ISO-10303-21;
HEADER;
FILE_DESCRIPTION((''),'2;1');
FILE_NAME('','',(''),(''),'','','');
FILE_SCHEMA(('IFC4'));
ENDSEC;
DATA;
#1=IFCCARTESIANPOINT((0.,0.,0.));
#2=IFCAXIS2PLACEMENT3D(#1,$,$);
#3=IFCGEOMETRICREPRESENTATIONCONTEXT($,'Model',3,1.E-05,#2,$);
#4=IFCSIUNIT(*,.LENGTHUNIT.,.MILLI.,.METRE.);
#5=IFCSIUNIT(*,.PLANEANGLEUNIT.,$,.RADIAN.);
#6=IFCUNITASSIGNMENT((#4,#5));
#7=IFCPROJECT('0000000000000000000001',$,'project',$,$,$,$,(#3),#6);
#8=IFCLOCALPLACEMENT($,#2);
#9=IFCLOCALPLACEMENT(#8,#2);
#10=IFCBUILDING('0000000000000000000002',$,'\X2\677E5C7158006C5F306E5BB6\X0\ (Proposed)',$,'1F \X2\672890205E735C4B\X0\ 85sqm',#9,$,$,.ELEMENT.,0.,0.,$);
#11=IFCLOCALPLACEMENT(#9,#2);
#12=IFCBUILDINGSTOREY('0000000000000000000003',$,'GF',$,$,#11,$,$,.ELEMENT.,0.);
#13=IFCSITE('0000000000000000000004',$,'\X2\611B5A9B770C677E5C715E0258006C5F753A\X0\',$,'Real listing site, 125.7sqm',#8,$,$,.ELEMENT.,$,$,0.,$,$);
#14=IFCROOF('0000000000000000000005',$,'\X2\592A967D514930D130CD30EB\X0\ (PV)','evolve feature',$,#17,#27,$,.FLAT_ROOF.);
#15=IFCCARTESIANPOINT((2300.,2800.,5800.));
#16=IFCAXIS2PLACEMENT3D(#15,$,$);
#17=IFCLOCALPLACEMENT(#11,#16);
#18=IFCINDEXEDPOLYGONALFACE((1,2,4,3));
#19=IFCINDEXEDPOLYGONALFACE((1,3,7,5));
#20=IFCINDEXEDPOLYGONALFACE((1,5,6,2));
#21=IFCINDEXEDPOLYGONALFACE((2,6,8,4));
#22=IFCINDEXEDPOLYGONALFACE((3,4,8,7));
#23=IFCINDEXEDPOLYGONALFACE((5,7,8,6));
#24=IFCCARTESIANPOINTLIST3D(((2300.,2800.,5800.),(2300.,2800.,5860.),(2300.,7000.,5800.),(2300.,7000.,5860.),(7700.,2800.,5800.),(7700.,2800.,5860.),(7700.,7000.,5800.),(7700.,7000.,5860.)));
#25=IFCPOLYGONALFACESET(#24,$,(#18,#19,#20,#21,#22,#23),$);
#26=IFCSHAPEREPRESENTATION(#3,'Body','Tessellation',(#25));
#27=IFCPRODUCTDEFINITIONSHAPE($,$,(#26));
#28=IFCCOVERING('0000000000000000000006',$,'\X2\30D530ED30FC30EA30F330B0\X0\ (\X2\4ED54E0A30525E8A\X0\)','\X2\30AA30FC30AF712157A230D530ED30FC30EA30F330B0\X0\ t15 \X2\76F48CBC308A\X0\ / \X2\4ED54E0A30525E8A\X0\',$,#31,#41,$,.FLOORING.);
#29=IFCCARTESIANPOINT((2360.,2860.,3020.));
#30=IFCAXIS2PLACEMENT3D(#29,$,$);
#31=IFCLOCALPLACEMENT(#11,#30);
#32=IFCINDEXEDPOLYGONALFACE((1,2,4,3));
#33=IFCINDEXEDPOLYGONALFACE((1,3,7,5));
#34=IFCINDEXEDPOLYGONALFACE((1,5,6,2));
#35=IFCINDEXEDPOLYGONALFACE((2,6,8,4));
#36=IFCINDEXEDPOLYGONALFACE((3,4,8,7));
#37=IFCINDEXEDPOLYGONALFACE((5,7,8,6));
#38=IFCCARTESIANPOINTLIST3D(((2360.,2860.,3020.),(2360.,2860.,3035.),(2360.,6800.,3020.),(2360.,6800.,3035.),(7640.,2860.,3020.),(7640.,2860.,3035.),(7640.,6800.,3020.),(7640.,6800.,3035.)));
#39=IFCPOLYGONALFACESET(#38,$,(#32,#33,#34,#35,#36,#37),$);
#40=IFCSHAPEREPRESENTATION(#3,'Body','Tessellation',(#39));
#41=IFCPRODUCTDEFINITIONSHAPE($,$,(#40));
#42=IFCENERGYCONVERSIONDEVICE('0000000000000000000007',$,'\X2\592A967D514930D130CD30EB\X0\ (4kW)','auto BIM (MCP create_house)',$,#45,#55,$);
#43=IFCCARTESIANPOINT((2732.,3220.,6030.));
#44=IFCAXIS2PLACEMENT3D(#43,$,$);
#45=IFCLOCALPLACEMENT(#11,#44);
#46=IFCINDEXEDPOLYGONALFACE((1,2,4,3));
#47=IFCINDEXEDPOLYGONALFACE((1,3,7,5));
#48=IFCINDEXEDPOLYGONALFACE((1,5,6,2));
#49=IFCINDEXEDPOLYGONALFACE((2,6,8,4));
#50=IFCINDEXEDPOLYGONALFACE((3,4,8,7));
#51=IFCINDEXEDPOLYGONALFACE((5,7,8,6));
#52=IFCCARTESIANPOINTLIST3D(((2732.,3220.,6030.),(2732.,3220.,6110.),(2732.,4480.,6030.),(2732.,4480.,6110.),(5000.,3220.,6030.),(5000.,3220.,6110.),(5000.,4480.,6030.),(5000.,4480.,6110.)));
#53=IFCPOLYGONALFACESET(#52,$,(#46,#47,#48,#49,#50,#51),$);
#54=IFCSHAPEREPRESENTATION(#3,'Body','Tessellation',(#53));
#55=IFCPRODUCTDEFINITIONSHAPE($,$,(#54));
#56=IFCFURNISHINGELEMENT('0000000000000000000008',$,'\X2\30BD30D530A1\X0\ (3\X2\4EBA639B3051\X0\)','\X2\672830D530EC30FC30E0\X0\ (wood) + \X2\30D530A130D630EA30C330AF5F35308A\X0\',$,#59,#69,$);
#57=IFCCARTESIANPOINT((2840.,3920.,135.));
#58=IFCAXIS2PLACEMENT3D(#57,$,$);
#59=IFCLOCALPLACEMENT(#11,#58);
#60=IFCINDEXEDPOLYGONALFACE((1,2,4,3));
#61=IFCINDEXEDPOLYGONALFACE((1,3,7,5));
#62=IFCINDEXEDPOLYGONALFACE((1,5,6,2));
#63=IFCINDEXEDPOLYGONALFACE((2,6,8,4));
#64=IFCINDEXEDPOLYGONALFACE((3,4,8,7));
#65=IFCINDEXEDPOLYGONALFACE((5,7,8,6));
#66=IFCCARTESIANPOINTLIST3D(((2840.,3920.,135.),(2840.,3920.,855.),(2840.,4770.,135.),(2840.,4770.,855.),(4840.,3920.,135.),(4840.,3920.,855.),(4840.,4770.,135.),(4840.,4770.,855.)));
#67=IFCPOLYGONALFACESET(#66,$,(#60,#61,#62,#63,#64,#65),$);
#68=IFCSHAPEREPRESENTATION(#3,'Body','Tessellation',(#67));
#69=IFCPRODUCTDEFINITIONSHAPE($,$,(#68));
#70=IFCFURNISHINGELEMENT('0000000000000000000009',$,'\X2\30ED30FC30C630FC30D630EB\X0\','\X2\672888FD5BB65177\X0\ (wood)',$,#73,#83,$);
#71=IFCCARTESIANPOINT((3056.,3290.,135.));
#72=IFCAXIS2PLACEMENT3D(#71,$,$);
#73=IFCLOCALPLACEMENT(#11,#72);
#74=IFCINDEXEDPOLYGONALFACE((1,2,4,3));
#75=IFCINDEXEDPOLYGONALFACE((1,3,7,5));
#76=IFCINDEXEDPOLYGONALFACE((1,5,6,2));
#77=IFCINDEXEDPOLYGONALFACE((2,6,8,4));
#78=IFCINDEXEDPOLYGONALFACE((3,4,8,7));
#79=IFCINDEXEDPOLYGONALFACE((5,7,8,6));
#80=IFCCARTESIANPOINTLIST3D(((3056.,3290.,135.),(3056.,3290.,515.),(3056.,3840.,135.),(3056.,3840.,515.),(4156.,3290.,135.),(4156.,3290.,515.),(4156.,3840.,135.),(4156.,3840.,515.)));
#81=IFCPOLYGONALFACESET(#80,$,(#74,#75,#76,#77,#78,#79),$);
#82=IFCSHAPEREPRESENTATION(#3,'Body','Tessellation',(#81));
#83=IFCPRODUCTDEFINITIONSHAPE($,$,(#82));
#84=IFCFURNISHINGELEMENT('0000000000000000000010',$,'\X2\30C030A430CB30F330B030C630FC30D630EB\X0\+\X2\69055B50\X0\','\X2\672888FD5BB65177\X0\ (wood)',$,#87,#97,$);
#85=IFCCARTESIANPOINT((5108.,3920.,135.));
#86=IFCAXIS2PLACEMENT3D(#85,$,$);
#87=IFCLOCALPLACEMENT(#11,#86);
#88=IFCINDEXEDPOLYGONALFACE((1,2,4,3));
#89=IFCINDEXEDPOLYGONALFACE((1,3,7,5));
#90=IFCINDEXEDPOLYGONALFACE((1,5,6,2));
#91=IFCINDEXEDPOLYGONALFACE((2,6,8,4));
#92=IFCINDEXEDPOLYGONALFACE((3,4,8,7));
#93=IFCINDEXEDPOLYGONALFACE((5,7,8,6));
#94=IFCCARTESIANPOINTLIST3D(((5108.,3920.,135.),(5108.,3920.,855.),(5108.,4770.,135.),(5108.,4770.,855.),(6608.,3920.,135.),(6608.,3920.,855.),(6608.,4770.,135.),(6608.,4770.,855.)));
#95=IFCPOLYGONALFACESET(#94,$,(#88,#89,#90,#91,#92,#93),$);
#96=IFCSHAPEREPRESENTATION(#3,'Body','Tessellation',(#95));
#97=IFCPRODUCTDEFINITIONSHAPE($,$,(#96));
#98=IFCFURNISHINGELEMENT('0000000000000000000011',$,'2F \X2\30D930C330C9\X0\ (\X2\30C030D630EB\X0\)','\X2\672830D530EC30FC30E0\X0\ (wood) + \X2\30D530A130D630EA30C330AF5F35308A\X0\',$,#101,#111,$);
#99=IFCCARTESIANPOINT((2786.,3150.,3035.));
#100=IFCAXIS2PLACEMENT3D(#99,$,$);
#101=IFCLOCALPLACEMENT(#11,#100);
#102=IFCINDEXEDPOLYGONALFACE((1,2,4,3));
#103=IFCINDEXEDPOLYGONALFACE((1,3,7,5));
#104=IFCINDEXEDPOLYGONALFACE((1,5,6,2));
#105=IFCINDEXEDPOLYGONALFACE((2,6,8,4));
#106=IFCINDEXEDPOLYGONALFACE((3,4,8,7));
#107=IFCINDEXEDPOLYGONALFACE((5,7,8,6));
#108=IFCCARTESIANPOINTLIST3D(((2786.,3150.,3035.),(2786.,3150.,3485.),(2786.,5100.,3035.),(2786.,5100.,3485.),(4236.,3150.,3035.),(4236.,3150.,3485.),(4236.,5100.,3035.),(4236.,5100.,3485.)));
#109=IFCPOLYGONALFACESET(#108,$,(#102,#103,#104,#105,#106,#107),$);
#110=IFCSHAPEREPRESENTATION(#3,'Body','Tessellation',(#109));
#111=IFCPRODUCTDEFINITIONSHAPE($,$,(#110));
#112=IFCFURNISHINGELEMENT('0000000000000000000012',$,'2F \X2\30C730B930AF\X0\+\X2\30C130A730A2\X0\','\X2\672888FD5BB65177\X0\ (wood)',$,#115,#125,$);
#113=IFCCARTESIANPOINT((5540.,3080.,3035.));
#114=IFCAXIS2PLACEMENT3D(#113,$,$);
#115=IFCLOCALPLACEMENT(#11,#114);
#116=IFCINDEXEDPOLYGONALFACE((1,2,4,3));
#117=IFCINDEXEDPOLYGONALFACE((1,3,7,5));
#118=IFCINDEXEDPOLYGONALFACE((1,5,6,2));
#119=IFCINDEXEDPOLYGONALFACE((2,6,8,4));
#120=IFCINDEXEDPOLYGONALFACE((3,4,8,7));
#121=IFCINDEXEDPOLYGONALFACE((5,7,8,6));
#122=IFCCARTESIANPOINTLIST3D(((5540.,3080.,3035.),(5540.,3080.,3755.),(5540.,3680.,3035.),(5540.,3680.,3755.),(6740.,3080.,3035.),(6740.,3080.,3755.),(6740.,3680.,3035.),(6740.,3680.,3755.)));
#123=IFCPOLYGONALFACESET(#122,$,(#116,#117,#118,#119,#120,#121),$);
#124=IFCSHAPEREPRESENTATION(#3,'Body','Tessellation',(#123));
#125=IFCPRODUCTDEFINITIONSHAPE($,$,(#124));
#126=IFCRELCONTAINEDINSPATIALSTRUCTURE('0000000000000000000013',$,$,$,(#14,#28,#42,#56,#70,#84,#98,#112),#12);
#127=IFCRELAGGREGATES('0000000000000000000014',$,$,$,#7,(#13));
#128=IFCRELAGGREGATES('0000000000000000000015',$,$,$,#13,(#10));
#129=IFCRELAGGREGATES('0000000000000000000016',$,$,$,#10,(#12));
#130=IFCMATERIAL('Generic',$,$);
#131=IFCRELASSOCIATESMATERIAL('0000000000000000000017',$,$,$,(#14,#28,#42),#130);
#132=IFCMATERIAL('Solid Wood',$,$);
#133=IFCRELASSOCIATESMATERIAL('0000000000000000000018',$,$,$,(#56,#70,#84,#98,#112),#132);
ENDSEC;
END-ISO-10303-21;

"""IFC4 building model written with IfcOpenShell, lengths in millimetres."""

from ifc_helpers import new_model, si_unit, frame, frame_2d, origin, place, context, project, spatial, rectangle, extrude, material, element, save


model = new_model("IFC4")

# Units and contexts
model_context = context("Model", 3, precision=1e-05, world=origin())
ifc_project = project(units=[si_unit("LENGTHUNIT", "METRE", prefix="MILLI"), si_unit("PLANEANGLEUNIT", "RADIAN")], contexts=[model_context])

# Site, building, storey
site_placement = place(None, origin())
site = spatial("IfcSite", under=ifc_project, at=site_placement, Name="愛媛県松山市堀江町", ObjectType="Real listing site, 125.7sqm", CompositionType="ELEMENT", RefElevation=0.0)
building_placement = place(site_placement, origin())
building = spatial("IfcBuilding", under=site, at=building_placement, Name="松山堀江の家 (Proposed)", ObjectType="1F 木造平屋 85sqm", CompositionType="ELEMENT", ElevationOfRefHeight=0.0, ElevationOfTerrain=0.0)
storey_placement = place(building_placement, origin())
storey = spatial("IfcBuildingStorey", under=building, at=storey_placement, Name="GF", CompositionType="ELEMENT", Elevation=0.0)

# Shared definitions
ifc_material_1 = material(Name="Solid Wood")

# Shared definitions
ifc_material_2 = material(Name="Generic")

# Roof
roof_placement = place(storey_placement, frame((2300.0, 2800.0, 5800.0)))
element("IfcRoof", 1, at=roof_placement, inside=storey, material=ifc_material_2, Name="太陽光パネル (PV)", Description="evolve feature", PredefinedType="FLAT_ROOF", context=model_context, shape_type="SweptSolid", body=[
    extrude(rectangle(XDim=5400.0, YDim=4200.0, at=frame_2d((2700.0, 2100.0))), frame((2300.0, 2800.0, 5800.0)), (0.0, 0.0, 1.0), 60.0),
])

# Covering
covering_placement = place(storey_placement, frame((2360.0, 2860.0, 3020.0)))
element("IfcCovering", 2, at=covering_placement, inside=storey, material=ifc_material_2, Name="フローリング (仕上げ床)", Description="オーク無垢フローリング t15 直貼り / 仕上げ床", PredefinedType="FLOORING", context=model_context, shape_type="SweptSolid", body=[
    extrude(rectangle(XDim=5280.0, YDim=3940.0, at=frame_2d((2640.0, 1970.0))), frame((2360.0, 2860.0, 3020.0)), (0.0, 0.0, 1.0), 15.0),
])

# Energy conversion device
energy_conversion_device_placement = place(storey_placement, frame((2732.0, 3220.0, 6030.0)))
element("IfcEnergyConversionDevice", 3, at=energy_conversion_device_placement, inside=storey, material=ifc_material_2, Name="太陽光パネル (4kW)", Description="auto BIM (MCP create_house)", context=model_context, shape_type="SweptSolid", body=[
    extrude(rectangle(XDim=2268.0, YDim=1260.0, at=frame_2d((1134.0, 630.0))), frame((2732.0, 3220.0, 6030.0)), (0.0, 0.0, 1.0), 80.0),
])

# Furnishing elements
furnishing_1_placement = place(storey_placement, frame((2840.0, 3920.0, 135.0)))
element("IfcFurnishingElement", 4, at=furnishing_1_placement, inside=storey, material=ifc_material_1, Name="ソファ (3人掛け)", Description="木フレーム (wood) + ファブリック張り", context=model_context, shape_type="SweptSolid", body=[
    extrude(rectangle(XDim=2000.0, YDim=850.0, at=frame_2d((1000.0, 425.0))), frame((2840.0, 3920.0, 135.0)), (0.0, 0.0, 1.0), 720.0),
])
furnishing_2_placement = place(storey_placement, frame((3056.0, 3290.0, 135.0)))
element("IfcFurnishingElement", 5, at=furnishing_2_placement, inside=storey, material=ifc_material_1, Name="ローテーブル", Description="木製家具 (wood)", context=model_context, shape_type="SweptSolid", body=[
    extrude(rectangle(XDim=1100.0, YDim=550.0, at=frame_2d((550.0, 275.0))), frame((3056.0, 3290.0, 135.0)), (0.0, 0.0, 1.0), 380.0),
])
furnishing_3_placement = place(storey_placement, frame((5108.0, 3920.0, 135.0)))
element("IfcFurnishingElement", 6, at=furnishing_3_placement, inside=storey, material=ifc_material_1, Name="ダイニングテーブル+椅子", Description="木製家具 (wood)", context=model_context, shape_type="SweptSolid", body=[
    extrude(rectangle(XDim=1500.0, YDim=850.0, at=frame_2d((750.0, 425.0))), frame((5108.0, 3920.0, 135.0)), (0.0, 0.0, 1.0), 720.0),
])
furnishing_4_placement = place(storey_placement, frame((2786.0, 3150.0, 3035.0)))
element("IfcFurnishingElement", 7, at=furnishing_4_placement, inside=storey, material=ifc_material_1, Name="2F ベッド (ダブル)", Description="木フレーム (wood) + ファブリック張り", context=model_context, shape_type="SweptSolid", body=[
    extrude(rectangle(XDim=1450.0, YDim=1950.0, at=frame_2d((725.0, 975.0))), frame((2786.0, 3150.0, 3035.0)), (0.0, 0.0, 1.0), 450.0),
])
furnishing_5_placement = place(storey_placement, frame((5540.0, 3080.0, 3035.0)))
element("IfcFurnishingElement", 8, at=furnishing_5_placement, inside=storey, material=ifc_material_1, Name="2F デスク+チェア", Description="木製家具 (wood)", context=model_context, shape_type="SweptSolid", body=[
    extrude(rectangle(XDim=1200.0, YDim=600.0, at=frame_2d((600.0, 300.0))), frame((5540.0, 3080.0, 3035.0)), (0.0, 0.0, 1.0), 720.0),
])

save(model, "model.ifc")
